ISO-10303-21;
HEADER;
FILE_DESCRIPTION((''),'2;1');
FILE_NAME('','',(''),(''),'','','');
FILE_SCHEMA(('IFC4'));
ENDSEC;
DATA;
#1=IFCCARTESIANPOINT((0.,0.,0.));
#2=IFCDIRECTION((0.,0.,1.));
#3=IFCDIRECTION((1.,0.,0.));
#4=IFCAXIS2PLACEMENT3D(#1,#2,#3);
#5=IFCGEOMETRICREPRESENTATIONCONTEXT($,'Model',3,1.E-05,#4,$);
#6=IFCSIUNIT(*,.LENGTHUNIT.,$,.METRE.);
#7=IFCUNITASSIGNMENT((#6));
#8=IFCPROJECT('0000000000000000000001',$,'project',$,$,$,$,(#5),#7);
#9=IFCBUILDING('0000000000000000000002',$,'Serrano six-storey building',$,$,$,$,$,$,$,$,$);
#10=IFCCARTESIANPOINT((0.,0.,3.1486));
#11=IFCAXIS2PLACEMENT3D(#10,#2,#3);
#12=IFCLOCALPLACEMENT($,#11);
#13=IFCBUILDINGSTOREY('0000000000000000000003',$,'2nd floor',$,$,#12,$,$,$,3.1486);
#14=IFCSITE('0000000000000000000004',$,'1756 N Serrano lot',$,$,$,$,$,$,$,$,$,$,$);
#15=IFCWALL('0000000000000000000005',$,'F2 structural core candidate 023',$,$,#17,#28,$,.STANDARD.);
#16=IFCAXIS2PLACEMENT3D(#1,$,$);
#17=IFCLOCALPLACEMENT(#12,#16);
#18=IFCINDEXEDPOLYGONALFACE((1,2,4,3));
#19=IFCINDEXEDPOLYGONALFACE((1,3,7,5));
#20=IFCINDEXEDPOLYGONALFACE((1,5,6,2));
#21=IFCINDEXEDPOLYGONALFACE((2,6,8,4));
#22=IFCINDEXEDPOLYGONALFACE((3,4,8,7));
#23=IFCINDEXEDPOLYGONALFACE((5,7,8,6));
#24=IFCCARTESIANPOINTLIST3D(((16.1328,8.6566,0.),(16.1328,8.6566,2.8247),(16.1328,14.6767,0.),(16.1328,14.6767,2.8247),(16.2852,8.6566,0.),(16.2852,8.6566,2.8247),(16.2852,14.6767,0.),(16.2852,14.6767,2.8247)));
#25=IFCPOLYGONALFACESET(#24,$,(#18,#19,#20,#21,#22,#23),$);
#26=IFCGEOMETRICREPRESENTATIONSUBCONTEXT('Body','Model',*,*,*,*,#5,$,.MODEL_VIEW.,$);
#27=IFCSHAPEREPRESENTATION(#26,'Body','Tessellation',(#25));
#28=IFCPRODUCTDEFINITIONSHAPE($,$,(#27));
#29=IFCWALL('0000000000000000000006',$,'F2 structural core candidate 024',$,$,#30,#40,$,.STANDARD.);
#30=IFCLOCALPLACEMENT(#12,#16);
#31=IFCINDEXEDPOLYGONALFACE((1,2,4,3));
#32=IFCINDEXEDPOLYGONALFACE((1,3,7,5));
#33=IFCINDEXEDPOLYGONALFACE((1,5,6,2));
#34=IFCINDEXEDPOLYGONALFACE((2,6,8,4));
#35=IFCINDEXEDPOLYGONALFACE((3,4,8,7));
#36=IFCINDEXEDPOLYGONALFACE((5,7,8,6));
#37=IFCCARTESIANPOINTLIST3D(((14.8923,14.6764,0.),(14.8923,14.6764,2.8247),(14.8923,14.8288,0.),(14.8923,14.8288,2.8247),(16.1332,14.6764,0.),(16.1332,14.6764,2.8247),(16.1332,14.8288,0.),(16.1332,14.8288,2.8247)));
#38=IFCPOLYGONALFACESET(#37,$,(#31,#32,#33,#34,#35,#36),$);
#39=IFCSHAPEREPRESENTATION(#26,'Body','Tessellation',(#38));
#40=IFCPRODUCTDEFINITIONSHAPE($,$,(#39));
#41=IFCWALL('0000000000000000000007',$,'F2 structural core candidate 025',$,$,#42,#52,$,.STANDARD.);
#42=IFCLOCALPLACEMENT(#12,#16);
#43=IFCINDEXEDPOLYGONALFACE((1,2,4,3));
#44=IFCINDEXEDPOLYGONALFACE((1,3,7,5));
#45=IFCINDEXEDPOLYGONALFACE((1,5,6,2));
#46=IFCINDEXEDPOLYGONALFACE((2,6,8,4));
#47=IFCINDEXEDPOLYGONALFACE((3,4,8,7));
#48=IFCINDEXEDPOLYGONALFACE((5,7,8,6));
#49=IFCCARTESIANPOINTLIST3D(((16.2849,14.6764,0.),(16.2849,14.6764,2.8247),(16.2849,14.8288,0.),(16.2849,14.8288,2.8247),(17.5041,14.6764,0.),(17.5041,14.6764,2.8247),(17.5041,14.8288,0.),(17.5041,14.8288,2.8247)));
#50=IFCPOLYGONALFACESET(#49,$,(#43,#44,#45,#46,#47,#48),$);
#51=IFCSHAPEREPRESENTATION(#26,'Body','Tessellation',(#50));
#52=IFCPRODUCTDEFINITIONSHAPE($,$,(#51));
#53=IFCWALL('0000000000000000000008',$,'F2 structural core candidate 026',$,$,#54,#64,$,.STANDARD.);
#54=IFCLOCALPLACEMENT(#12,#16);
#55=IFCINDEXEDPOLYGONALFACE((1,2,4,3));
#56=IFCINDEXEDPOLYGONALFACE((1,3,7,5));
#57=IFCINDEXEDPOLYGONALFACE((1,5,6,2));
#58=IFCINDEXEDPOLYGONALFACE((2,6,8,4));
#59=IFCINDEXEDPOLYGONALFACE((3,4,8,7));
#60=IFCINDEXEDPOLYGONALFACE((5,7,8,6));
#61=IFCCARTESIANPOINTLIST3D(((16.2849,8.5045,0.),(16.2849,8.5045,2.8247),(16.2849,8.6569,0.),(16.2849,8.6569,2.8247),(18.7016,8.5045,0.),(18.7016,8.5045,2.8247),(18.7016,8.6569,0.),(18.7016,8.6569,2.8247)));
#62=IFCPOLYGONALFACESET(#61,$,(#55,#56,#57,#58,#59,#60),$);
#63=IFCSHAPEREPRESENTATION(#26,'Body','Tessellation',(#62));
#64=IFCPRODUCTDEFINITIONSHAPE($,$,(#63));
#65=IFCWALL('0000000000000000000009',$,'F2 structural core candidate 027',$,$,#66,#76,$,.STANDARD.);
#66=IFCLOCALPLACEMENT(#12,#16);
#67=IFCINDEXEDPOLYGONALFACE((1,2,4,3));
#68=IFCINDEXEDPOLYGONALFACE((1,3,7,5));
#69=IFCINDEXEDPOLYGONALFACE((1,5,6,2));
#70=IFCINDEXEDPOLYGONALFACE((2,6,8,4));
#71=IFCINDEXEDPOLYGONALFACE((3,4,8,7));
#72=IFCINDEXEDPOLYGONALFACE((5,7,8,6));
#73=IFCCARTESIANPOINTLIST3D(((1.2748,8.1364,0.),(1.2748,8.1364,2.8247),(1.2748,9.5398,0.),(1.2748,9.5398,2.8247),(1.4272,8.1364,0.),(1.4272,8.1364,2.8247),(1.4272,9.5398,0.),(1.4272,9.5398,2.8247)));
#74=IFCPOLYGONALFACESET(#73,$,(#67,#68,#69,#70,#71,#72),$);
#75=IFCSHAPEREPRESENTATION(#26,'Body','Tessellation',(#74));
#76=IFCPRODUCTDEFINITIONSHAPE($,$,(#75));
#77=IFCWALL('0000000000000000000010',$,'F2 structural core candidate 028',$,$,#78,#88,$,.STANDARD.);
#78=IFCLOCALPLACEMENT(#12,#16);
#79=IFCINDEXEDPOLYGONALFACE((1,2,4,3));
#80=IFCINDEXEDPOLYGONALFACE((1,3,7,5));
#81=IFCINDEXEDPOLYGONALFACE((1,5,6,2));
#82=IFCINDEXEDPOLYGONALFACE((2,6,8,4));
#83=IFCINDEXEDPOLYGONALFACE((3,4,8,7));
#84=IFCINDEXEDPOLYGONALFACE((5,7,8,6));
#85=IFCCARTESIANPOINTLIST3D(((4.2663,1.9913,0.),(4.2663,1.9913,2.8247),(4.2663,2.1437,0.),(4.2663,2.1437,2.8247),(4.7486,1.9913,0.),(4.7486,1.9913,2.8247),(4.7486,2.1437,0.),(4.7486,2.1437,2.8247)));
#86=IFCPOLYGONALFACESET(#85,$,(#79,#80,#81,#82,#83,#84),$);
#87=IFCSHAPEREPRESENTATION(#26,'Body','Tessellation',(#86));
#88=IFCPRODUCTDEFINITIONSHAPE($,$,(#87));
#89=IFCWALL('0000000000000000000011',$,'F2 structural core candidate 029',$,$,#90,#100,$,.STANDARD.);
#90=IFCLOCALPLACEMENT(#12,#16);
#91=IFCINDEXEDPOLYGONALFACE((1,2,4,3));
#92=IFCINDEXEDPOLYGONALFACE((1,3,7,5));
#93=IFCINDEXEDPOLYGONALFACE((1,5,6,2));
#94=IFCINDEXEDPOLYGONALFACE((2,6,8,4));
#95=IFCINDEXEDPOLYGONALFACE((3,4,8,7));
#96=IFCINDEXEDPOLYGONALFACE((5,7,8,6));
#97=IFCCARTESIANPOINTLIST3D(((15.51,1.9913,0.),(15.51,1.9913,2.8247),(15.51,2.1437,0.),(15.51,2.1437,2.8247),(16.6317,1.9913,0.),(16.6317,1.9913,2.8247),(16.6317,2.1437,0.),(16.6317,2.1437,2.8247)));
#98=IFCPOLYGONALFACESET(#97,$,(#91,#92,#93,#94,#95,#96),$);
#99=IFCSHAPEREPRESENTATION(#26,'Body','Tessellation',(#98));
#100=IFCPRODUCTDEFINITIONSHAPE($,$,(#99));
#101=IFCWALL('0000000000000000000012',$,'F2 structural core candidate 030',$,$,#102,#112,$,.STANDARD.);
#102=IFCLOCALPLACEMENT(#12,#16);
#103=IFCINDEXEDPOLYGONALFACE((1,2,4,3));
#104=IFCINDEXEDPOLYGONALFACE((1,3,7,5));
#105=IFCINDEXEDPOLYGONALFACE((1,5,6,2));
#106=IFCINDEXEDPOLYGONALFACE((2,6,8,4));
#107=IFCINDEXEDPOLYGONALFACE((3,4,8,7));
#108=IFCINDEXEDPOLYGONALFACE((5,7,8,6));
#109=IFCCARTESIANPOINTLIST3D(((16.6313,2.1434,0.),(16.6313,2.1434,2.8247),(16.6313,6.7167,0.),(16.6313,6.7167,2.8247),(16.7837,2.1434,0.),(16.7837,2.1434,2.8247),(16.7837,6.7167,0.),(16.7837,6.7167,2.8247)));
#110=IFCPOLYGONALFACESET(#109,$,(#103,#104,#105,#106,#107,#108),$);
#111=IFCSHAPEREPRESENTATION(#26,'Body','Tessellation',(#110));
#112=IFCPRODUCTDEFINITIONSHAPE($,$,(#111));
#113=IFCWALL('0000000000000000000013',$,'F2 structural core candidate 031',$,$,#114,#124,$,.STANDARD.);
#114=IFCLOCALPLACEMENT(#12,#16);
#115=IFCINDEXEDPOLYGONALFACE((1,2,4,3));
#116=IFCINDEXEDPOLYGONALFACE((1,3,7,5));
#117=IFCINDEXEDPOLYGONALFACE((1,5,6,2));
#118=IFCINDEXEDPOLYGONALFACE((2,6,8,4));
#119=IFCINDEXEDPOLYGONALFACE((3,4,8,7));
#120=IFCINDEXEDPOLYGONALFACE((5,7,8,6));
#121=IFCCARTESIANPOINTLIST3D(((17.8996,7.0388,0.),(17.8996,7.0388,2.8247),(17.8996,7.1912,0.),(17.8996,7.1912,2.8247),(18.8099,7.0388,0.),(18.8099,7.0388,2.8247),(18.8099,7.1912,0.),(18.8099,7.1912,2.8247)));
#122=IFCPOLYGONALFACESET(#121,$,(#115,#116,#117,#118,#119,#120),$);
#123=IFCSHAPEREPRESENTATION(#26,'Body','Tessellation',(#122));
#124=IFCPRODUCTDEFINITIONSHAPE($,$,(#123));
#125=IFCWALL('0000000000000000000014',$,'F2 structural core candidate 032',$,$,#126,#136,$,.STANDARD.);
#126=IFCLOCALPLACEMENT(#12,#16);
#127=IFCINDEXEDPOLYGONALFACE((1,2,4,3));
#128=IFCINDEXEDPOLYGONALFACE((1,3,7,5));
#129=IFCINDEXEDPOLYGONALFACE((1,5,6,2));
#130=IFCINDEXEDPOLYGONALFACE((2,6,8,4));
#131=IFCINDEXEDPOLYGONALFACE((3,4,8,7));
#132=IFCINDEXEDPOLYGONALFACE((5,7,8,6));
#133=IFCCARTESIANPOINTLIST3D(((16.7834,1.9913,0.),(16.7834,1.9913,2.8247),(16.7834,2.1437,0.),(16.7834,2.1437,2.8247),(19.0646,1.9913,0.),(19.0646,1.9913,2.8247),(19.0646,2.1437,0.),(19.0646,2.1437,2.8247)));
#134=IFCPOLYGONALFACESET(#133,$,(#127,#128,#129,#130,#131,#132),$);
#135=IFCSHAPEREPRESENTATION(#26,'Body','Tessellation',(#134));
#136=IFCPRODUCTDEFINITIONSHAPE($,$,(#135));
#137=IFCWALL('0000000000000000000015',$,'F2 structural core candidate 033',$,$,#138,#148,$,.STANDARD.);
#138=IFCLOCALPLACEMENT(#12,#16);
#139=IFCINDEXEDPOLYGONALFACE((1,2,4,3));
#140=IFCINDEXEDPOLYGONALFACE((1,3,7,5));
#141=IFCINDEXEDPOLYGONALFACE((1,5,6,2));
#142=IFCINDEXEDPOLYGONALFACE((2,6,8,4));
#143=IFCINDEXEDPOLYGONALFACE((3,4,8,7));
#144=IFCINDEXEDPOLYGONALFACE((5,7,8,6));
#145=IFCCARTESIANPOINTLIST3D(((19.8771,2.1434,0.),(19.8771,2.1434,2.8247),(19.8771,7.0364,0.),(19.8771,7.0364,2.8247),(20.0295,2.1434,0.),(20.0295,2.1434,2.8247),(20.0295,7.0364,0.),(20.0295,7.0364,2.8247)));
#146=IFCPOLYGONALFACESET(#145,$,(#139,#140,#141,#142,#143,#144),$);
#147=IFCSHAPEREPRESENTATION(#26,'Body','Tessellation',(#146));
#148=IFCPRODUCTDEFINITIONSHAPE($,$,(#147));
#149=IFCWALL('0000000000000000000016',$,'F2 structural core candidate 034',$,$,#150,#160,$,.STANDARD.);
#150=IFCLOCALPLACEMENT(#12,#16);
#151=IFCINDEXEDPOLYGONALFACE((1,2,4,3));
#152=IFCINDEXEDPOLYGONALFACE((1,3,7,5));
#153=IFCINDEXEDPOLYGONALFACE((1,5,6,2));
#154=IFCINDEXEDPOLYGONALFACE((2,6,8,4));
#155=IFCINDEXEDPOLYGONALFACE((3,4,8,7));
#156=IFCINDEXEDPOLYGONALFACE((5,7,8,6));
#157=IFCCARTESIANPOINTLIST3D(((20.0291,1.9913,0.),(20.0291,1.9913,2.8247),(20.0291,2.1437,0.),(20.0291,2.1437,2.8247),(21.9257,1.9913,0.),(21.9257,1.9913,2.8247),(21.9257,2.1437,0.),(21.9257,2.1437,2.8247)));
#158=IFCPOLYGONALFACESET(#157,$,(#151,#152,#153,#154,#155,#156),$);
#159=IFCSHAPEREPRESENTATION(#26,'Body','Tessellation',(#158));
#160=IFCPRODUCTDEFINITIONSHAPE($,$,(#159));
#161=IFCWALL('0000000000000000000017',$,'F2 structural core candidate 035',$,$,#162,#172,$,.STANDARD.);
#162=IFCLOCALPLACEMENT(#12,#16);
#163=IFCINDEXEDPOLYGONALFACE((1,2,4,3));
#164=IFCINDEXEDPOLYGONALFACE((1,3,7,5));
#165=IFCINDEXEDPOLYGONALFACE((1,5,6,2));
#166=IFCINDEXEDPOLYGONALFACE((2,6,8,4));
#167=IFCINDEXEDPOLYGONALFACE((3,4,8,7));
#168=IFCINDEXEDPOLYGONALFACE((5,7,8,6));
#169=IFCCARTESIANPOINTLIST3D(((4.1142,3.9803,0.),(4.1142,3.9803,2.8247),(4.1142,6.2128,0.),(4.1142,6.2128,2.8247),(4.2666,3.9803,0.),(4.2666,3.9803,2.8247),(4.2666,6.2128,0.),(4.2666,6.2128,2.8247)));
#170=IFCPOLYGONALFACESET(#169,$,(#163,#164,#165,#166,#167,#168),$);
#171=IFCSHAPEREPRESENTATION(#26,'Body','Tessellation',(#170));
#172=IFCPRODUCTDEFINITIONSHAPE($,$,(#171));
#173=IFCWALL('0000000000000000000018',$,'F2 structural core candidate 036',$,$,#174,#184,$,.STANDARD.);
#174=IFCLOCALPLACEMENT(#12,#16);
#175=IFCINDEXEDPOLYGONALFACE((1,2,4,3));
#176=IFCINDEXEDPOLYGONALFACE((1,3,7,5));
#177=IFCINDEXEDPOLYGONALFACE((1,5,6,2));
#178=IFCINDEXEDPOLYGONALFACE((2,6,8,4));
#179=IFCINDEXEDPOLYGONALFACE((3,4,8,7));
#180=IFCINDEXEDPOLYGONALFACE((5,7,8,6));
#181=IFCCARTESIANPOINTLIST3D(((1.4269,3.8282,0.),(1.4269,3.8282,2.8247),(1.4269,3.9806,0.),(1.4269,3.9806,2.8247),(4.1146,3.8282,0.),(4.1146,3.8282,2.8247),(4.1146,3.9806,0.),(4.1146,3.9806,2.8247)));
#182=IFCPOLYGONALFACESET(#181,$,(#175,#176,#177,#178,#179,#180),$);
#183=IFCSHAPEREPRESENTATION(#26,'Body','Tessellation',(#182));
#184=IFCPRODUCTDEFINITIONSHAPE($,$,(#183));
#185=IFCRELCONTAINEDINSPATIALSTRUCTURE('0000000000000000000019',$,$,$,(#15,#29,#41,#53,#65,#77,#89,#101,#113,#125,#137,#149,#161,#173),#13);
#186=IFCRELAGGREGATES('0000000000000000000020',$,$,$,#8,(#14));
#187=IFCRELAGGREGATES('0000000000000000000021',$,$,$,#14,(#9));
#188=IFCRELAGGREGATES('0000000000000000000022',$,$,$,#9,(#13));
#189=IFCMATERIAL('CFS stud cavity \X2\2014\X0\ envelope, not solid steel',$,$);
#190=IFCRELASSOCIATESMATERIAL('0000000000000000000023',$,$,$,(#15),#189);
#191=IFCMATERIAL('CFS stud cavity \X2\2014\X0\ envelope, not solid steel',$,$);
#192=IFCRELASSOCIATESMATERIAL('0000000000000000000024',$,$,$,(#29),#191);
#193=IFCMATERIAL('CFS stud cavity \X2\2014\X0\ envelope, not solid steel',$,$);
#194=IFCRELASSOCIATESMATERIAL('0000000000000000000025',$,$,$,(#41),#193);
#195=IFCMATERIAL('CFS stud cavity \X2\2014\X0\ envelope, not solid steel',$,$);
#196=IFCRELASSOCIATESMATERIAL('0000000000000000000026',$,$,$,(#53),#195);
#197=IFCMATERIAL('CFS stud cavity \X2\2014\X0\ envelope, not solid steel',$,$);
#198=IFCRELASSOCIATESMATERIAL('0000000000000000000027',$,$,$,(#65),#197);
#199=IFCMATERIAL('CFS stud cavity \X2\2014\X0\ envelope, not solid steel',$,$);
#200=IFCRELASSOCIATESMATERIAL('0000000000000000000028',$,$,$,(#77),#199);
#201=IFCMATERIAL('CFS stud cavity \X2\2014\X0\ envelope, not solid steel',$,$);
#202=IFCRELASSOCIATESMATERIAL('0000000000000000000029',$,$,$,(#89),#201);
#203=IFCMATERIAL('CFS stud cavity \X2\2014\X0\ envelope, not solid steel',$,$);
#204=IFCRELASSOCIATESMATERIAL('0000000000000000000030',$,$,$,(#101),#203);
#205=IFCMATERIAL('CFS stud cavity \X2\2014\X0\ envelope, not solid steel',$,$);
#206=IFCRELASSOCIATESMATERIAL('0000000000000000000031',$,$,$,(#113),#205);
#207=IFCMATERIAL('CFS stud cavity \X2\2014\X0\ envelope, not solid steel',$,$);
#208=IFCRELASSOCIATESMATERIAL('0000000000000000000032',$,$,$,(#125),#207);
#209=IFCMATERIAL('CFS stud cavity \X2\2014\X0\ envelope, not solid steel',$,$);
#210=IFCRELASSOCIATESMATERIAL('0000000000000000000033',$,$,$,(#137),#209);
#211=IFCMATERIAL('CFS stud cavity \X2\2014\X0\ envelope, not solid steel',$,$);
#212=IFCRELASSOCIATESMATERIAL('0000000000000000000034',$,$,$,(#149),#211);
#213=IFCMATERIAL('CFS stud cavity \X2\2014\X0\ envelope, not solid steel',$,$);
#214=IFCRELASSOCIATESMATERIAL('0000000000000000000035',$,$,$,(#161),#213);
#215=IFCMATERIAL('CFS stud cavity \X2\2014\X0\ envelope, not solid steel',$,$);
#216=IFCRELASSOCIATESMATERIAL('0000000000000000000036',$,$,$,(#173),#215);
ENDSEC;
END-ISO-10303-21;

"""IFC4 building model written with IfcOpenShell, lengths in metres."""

from ifc_helpers import new_model, si_unit, frame, origin_with_axes, place, context, subcontext, project, spatial, polyline, outline, extrude, material, element, save


model = new_model("IFC4")

# Units and contexts
model_context = context("Model", 3, precision=1e-05, world=origin_with_axes())
body_context = subcontext(model_context, "Body", "Model", "MODEL_VIEW")
ifc_project = project(units=[si_unit("LENGTHUNIT", "METRE")], contexts=[model_context])

# Site, building, storey
site = spatial("IfcSite", under=ifc_project, Name="1756 N Serrano lot")
building = spatial("IfcBuilding", under=site, Name="Serrano six-storey building")
storey_placement = place(None, frame((0.0, 0.0, 3.1486), z_axis=(0.0, 0.0, 1.0), x_axis=(1.0, 0.0, 0.0)))
storey = spatial("IfcBuildingStorey", under=building, at=storey_placement, Name="2nd floor", Elevation=3.1486)

# Walls
ifc_material_1 = material(Name="CFS stud cavity — envelope, not solid steel")
wall_1_placement = place(storey_placement, frame((0.0, 0.0, -3.1486), z_axis=(0.0, 0.0, 1.0), x_axis=(1.0, 0.0, 0.0)))
element("IfcWall", 1, at=wall_1_placement, inside=storey, material=ifc_material_1, Name="F2 structural core candidate 023", PredefinedType="STANDARD", context=body_context, shape_type="SweptSolid", body=[
    extrude(outline(polyline([(16.2852, 8.6566), (16.1328, 8.6566), (16.1328, 14.6767), (16.2852, 14.6767), (16.2852, 8.6566)])), frame((0.0, 0.0, 3.1486)), (0.0, 0.0, 1.0), 2.8247),
])
ifc_material_2 = material(Name="CFS stud cavity — envelope, not solid steel")
wall_2_placement = place(storey_placement, frame((0.0, 0.0, -3.1486), z_axis=(0.0, 0.0, 1.0), x_axis=(1.0, 0.0, 0.0)))
element("IfcWall", 2, at=wall_2_placement, inside=storey, material=ifc_material_2, Name="F2 structural core candidate 024", PredefinedType="STANDARD", context=body_context, shape_type="SweptSolid", body=[
    extrude(outline(polyline([(16.1332, 14.8288), (16.1332, 14.6764), (14.8923, 14.6764), (14.8923, 14.8288), (16.1332, 14.8288)])), frame((0.0, 0.0, 3.1486)), (0.0, 0.0, 1.0), 2.8247),
])
ifc_material_3 = material(Name="CFS stud cavity — envelope, not solid steel")
wall_3_placement = place(storey_placement, frame((0.0, 0.0, -3.1486), z_axis=(0.0, 0.0, 1.0), x_axis=(1.0, 0.0, 0.0)))
element("IfcWall", 3, at=wall_3_placement, inside=storey, material=ifc_material_3, Name="F2 structural core candidate 025", PredefinedType="STANDARD", context=body_context, shape_type="SweptSolid", body=[
    extrude(outline(polyline([(17.5041, 14.8288), (17.5041, 14.6764), (16.2849, 14.6764), (16.2849, 14.8288), (17.5041, 14.8288)])), frame((0.0, 0.0, 3.1486)), (0.0, 0.0, 1.0), 2.8247),
])
ifc_material_4 = material(Name="CFS stud cavity — envelope, not solid steel")
wall_4_placement = place(storey_placement, frame((0.0, 0.0, -3.1486), z_axis=(0.0, 0.0, 1.0), x_axis=(1.0, 0.0, 0.0)))
element("IfcWall", 4, at=wall_4_placement, inside=storey, material=ifc_material_4, Name="F2 structural core candidate 026", PredefinedType="STANDARD", context=body_context, shape_type="SweptSolid", body=[
    extrude(outline(polyline([(18.7016, 8.6569), (18.7016, 8.5045), (16.2849, 8.5045), (16.2849, 8.6569), (18.7016, 8.6569)])), frame((0.0, 0.0, 3.1486)), (0.0, 0.0, 1.0), 2.8247),
])
ifc_material_5 = material(Name="CFS stud cavity — envelope, not solid steel")
wall_5_placement = place(storey_placement, frame((0.0, 0.0, -3.1486), z_axis=(0.0, 0.0, 1.0), x_axis=(1.0, 0.0, 0.0)))
element("IfcWall", 5, at=wall_5_placement, inside=storey, material=ifc_material_5, Name="F2 structural core candidate 027", PredefinedType="STANDARD", context=body_context, shape_type="SweptSolid", body=[
    extrude(outline(polyline([(1.4272, 8.1364), (1.2748, 8.1364), (1.2748, 9.5398), (1.4272, 9.5398), (1.4272, 8.1364)])), frame((0.0, 0.0, 3.1486)), (0.0, 0.0, 1.0), 2.8247),
])
ifc_material_6 = material(Name="CFS stud cavity — envelope, not solid steel")
wall_6_placement = place(storey_placement, frame((0.0, 0.0, -3.1486), z_axis=(0.0, 0.0, 1.0), x_axis=(1.0, 0.0, 0.0)))
element("IfcWall", 6, at=wall_6_placement, inside=storey, material=ifc_material_6, Name="F2 structural core candidate 028", PredefinedType="STANDARD", context=body_context, shape_type="SweptSolid", body=[
    extrude(outline(polyline([(4.7486, 2.1437), (4.7486, 1.9913), (4.2663, 1.9913), (4.2663, 2.1437), (4.7486, 2.1437)])), frame((0.0, 0.0, 3.1486)), (0.0, 0.0, 1.0), 2.8247),
])
ifc_material_7 = material(Name="CFS stud cavity — envelope, not solid steel")
wall_7_placement = place(storey_placement, frame((0.0, 0.0, -3.1486), z_axis=(0.0, 0.0, 1.0), x_axis=(1.0, 0.0, 0.0)))
element("IfcWall", 7, at=wall_7_placement, inside=storey, material=ifc_material_7, Name="F2 structural core candidate 029", PredefinedType="STANDARD", context=body_context, shape_type="SweptSolid", body=[
    extrude(outline(polyline([(16.6317, 2.1437), (16.6317, 1.9913), (15.51, 1.9913), (15.51, 2.1437), (16.6317, 2.1437)])), frame((0.0, 0.0, 3.1486)), (0.0, 0.0, 1.0), 2.8247),
])
ifc_material_8 = material(Name="CFS stud cavity — envelope, not solid steel")
wall_8_placement = place(storey_placement, frame((0.0, 0.0, -3.1486), z_axis=(0.0, 0.0, 1.0), x_axis=(1.0, 0.0, 0.0)))
element("IfcWall", 8, at=wall_8_placement, inside=storey, material=ifc_material_8, Name="F2 structural core candidate 030", PredefinedType="STANDARD", context=body_context, shape_type="SweptSolid", body=[
    extrude(outline(polyline([(16.7837, 2.1434), (16.6313, 2.1434), (16.6313, 6.7167), (16.7837, 6.7167), (16.7837, 2.1434)])), frame((0.0, 0.0, 3.1486)), (0.0, 0.0, 1.0), 2.8247),
])
ifc_material_9 = material(Name="CFS stud cavity — envelope, not solid steel")
wall_9_placement = place(storey_placement, frame((0.0, 0.0, -3.1486), z_axis=(0.0, 0.0, 1.0), x_axis=(1.0, 0.0, 0.0)))
element("IfcWall", 9, at=wall_9_placement, inside=storey, material=ifc_material_9, Name="F2 structural core candidate 031", PredefinedType="STANDARD", context=body_context, shape_type="SweptSolid", body=[
    extrude(outline(polyline([(18.8099, 7.1912), (18.8099, 7.0388), (17.8996, 7.0388), (17.8996, 7.1912), (18.8099, 7.1912)])), frame((0.0, 0.0, 3.1486)), (0.0, 0.0, 1.0), 2.8247),
])
ifc_material_10 = material(Name="CFS stud cavity — envelope, not solid steel")
wall_10_placement = place(storey_placement, frame((0.0, 0.0, -3.1486), z_axis=(0.0, 0.0, 1.0), x_axis=(1.0, 0.0, 0.0)))
element("IfcWall", 10, at=wall_10_placement, inside=storey, material=ifc_material_10, Name="F2 structural core candidate 032", PredefinedType="STANDARD", context=body_context, shape_type="SweptSolid", body=[
    extrude(outline(polyline([(19.0646, 2.1437), (19.0646, 1.9913), (16.7834, 1.9913), (16.7834, 2.1437), (19.0646, 2.1437)])), frame((0.0, 0.0, 3.1486)), (0.0, 0.0, 1.0), 2.8247),
])
ifc_material_11 = material(Name="CFS stud cavity — envelope, not solid steel")
wall_11_placement = place(storey_placement, frame((0.0, 0.0, -3.1486), z_axis=(0.0, 0.0, 1.0), x_axis=(1.0, 0.0, 0.0)))
element("IfcWall", 11, at=wall_11_placement, inside=storey, material=ifc_material_11, Name="F2 structural core candidate 033", PredefinedType="STANDARD", context=body_context, shape_type="SweptSolid", body=[
    extrude(outline(polyline([(20.0295, 2.1434), (19.8771, 2.1434), (19.8771, 7.0364), (20.0295, 7.0364), (20.0295, 2.1434)])), frame((0.0, 0.0, 3.1486)), (0.0, 0.0, 1.0), 2.8247),
])
ifc_material_12 = material(Name="CFS stud cavity — envelope, not solid steel")
wall_12_placement = place(storey_placement, frame((0.0, 0.0, -3.1486), z_axis=(0.0, 0.0, 1.0), x_axis=(1.0, 0.0, 0.0)))
element("IfcWall", 12, at=wall_12_placement, inside=storey, material=ifc_material_12, Name="F2 structural core candidate 034", PredefinedType="STANDARD", context=body_context, shape_type="SweptSolid", body=[
    extrude(outline(polyline([(21.9257, 2.1437), (21.9257, 1.9913), (20.0291, 1.9913), (20.0291, 2.1437), (21.9257, 2.1437)])), frame((0.0, 0.0, 3.1486)), (0.0, 0.0, 1.0), 2.8247),
])
ifc_material_13 = material(Name="CFS stud cavity — envelope, not solid steel")
wall_13_placement = place(storey_placement, frame((0.0, 0.0, -3.1486), z_axis=(0.0, 0.0, 1.0), x_axis=(1.0, 0.0, 0.0)))
element("IfcWall", 13, at=wall_13_placement, inside=storey, material=ifc_material_13, Name="F2 structural core candidate 035", PredefinedType="STANDARD", context=body_context, shape_type="SweptSolid", body=[
    extrude(outline(polyline([(4.2666, 3.9803), (4.1142, 3.9803), (4.1142, 6.2128), (4.2666, 6.2128), (4.2666, 3.9803)])), frame((0.0, 0.0, 3.1486)), (0.0, 0.0, 1.0), 2.8247),
])
ifc_material_14 = material(Name="CFS stud cavity — envelope, not solid steel")
wall_14_placement = place(storey_placement, frame((0.0, 0.0, -3.1486), z_axis=(0.0, 0.0, 1.0), x_axis=(1.0, 0.0, 0.0)))
element("IfcWall", 14, at=wall_14_placement, inside=storey, material=ifc_material_14, Name="F2 structural core candidate 036", PredefinedType="STANDARD", context=body_context, shape_type="SweptSolid", body=[
    extrude(outline(polyline([(4.1146, 3.9806), (4.1146, 3.8282), (1.4269, 3.8282), (1.4269, 3.9806), (4.1146, 3.9806)])), frame((0.0, 0.0, 3.1486)), (0.0, 0.0, 1.0), 2.8247),
])

save(model, "model.ifc")
